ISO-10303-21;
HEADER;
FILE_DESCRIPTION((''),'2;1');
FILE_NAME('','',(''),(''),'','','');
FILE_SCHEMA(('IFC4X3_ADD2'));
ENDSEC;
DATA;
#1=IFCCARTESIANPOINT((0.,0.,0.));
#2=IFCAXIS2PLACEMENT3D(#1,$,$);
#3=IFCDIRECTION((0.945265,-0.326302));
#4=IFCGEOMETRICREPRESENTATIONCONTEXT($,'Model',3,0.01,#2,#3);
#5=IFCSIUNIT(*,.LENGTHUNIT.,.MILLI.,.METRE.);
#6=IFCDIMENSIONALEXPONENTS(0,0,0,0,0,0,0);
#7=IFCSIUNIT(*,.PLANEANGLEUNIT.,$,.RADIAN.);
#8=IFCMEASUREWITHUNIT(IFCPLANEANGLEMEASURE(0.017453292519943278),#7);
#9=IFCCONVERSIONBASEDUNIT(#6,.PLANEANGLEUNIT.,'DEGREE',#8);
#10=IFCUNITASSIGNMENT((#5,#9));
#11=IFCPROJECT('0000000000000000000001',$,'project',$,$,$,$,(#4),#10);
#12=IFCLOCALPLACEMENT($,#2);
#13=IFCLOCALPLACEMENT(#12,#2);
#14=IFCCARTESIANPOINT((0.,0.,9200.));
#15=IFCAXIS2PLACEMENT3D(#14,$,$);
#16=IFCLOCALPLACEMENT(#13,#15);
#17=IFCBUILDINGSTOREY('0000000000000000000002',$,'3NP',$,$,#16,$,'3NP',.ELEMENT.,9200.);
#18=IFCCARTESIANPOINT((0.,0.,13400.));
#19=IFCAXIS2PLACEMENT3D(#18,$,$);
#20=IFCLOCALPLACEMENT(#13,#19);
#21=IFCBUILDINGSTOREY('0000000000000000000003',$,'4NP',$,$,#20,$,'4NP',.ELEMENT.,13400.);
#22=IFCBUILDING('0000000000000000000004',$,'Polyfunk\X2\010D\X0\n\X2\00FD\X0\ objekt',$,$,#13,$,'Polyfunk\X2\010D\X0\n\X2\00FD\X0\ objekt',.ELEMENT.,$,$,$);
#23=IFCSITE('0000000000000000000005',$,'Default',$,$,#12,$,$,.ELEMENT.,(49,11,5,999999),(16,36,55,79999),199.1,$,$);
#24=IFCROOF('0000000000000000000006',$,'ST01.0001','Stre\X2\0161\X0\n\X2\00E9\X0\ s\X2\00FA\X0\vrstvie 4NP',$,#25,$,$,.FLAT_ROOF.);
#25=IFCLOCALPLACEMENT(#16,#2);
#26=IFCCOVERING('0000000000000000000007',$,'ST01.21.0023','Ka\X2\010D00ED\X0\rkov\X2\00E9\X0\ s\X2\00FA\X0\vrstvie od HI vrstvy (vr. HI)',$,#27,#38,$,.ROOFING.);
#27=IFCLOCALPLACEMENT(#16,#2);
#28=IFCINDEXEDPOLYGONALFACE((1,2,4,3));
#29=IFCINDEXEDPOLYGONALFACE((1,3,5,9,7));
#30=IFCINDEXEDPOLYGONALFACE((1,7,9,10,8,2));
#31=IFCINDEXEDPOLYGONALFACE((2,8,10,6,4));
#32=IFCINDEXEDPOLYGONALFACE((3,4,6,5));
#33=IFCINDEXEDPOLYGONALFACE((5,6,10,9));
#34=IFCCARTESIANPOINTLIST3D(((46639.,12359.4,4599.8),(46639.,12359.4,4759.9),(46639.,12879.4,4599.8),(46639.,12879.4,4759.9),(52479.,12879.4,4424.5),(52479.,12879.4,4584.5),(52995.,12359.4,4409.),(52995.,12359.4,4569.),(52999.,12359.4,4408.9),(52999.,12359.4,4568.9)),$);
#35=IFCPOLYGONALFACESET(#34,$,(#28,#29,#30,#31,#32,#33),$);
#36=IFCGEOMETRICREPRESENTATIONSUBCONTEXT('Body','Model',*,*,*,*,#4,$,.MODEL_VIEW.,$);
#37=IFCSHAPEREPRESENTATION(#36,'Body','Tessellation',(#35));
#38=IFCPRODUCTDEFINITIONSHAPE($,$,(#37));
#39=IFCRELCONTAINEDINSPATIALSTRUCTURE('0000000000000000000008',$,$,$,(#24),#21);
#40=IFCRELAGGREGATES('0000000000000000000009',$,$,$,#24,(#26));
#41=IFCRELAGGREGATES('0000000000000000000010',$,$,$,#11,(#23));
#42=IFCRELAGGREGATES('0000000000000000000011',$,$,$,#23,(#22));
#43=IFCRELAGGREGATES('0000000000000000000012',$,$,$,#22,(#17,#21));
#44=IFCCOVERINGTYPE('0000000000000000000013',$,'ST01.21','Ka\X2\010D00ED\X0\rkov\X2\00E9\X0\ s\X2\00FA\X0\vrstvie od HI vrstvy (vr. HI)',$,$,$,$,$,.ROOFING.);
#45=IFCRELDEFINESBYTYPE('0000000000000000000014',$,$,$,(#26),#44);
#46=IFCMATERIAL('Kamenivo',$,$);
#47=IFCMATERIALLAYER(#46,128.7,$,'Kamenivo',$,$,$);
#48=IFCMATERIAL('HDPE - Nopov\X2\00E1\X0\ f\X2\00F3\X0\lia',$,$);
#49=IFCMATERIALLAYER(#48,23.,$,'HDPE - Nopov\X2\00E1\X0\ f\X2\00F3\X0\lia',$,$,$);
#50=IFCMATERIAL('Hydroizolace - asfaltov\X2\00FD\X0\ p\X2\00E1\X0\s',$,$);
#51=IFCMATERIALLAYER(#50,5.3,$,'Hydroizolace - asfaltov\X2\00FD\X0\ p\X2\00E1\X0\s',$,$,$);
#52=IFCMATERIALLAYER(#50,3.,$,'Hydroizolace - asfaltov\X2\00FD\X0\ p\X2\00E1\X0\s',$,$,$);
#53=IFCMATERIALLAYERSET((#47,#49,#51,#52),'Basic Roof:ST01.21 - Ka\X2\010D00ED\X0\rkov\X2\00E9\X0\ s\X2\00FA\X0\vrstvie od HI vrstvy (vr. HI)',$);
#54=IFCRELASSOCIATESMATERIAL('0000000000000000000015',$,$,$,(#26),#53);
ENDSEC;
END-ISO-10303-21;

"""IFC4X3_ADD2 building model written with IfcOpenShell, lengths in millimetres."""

from ifc_helpers import new_model, entity, si_unit, converted_unit, direction, frame, origin, place, context, subcontext, project, spatial, polyline, outline, extrude, material, layer, layer_set, type_object, element, aggregate, save


model = new_model("IFC4X3_ADD2")

# Units and contexts
model_context = context("Model", 3, precision=0.01, world=origin(), true_north=direction((0.945265, -0.326302)))
body_context = subcontext(model_context, "Body", "Model", "MODEL_VIEW")
ifc_project = project(units=[si_unit("LENGTHUNIT", "METRE", prefix="MILLI"), converted_unit("PLANEANGLEUNIT", "DEGREE", entity("IfcPlaneAngleMeasure", 0.017453292519943278), si_unit("PLANEANGLEUNIT", "RADIAN"), dimensions=[0, 0, 0, 0, 0, 0, 0])], contexts=[model_context])

# Site, building, storey
site_placement = place(None, origin())
site = spatial("IfcSite", under=ifc_project, at=site_placement, Name="Default", CompositionType="ELEMENT", RefLatitude=(49, 11, 5, 999999), RefLongitude=(16, 36, 55, 79999), RefElevation=199.1)
building_placement = place(site_placement, origin())
building = spatial("IfcBuilding", under=site, at=building_placement, Name="Polyfunkčný objekt", LongName="Polyfunkčný objekt", CompositionType="ELEMENT")
storey_1_placement = place(building_placement, frame((0.0, 0.0, 9200.0)))
storey_1 = spatial("IfcBuildingStorey", under=building, at=storey_1_placement, Name="3NP", LongName="3NP", CompositionType="ELEMENT", Elevation=9200.0)

# Shared definitions
storey_2_placement = place(building_placement, frame((0.0, 0.0, 13400.0)))
storey_2 = spatial("IfcBuildingStorey", under=building, at=storey_2_placement, Name="4NP", LongName="4NP", CompositionType="ELEMENT", Elevation=13400.0)

# Roof, covering
roof = element("IfcRoof", 1, inside=storey_2, Name="ST01.0001", Description="Strešné súvrstvie 4NP", PredefinedType="FLAT_ROOF")
ifc_material_1 = material(Name="Kamenivo")
ifc_layer_1 = layer(ifc_material_1, 128.7, Name="Kamenivo")
ifc_material_2 = material(Name="HDPE - Nopová fólia")
ifc_layer_2 = layer(ifc_material_2, 23.0, Name="HDPE - Nopová fólia")
ifc_material_3 = material(Name="Hydroizolace - asfaltový pás")
ifc_layer_3 = layer(ifc_material_3, 5.3, Name="Hydroizolace - asfaltový pás")
ifc_layer_4 = layer(ifc_material_3, 3.0, Name="Hydroizolace - asfaltový pás")
ifc_layer_set_1 = layer_set([ifc_layer_1, ifc_layer_2, ifc_layer_3, ifc_layer_4], Name="Basic Roof:ST01.21 - Kačírkové súvrstvie od HI vrstvy (vr. HI)")
covering_type = type_object("IfcCoveringType", Name="ST01.21", Description="Kačírkové súvrstvie od HI vrstvy (vr. HI)", PredefinedType="ROOFING")
placement_1 = place(storey_2_placement, frame((46639.0, 12359.4, 208.9)))
covering_1_placement = place(placement_1, origin())
covering_1 = element("IfcCovering", 2, at=covering_1_placement, type_object=covering_type, material=ifc_layer_set_1, Name="ST01.21.0023", Description="Kačírkové súvrstvie od HI vrstvy (vr. HI)", PredefinedType="ROOFING", context=body_context, shape_type="SweptSolid", body=[
    extrude(outline(polyline([(2661.2, 260.0), (-3181.4, 260.0), (-3181.4, -260.0), (3177.4, -260.0), (3181.4, -260.0), (2661.2, 260.0)])), frame((3180.0, 260.0, 95.5), z_axis=(0.030015, 0.0, 0.999549), x_axis=(0.999549, 0.0, -0.030015)), (-0.030015, 0.0, 0.999549), 160.1),
])
aggregate(roof, [covering_1])

save(model, "model.ifc")
